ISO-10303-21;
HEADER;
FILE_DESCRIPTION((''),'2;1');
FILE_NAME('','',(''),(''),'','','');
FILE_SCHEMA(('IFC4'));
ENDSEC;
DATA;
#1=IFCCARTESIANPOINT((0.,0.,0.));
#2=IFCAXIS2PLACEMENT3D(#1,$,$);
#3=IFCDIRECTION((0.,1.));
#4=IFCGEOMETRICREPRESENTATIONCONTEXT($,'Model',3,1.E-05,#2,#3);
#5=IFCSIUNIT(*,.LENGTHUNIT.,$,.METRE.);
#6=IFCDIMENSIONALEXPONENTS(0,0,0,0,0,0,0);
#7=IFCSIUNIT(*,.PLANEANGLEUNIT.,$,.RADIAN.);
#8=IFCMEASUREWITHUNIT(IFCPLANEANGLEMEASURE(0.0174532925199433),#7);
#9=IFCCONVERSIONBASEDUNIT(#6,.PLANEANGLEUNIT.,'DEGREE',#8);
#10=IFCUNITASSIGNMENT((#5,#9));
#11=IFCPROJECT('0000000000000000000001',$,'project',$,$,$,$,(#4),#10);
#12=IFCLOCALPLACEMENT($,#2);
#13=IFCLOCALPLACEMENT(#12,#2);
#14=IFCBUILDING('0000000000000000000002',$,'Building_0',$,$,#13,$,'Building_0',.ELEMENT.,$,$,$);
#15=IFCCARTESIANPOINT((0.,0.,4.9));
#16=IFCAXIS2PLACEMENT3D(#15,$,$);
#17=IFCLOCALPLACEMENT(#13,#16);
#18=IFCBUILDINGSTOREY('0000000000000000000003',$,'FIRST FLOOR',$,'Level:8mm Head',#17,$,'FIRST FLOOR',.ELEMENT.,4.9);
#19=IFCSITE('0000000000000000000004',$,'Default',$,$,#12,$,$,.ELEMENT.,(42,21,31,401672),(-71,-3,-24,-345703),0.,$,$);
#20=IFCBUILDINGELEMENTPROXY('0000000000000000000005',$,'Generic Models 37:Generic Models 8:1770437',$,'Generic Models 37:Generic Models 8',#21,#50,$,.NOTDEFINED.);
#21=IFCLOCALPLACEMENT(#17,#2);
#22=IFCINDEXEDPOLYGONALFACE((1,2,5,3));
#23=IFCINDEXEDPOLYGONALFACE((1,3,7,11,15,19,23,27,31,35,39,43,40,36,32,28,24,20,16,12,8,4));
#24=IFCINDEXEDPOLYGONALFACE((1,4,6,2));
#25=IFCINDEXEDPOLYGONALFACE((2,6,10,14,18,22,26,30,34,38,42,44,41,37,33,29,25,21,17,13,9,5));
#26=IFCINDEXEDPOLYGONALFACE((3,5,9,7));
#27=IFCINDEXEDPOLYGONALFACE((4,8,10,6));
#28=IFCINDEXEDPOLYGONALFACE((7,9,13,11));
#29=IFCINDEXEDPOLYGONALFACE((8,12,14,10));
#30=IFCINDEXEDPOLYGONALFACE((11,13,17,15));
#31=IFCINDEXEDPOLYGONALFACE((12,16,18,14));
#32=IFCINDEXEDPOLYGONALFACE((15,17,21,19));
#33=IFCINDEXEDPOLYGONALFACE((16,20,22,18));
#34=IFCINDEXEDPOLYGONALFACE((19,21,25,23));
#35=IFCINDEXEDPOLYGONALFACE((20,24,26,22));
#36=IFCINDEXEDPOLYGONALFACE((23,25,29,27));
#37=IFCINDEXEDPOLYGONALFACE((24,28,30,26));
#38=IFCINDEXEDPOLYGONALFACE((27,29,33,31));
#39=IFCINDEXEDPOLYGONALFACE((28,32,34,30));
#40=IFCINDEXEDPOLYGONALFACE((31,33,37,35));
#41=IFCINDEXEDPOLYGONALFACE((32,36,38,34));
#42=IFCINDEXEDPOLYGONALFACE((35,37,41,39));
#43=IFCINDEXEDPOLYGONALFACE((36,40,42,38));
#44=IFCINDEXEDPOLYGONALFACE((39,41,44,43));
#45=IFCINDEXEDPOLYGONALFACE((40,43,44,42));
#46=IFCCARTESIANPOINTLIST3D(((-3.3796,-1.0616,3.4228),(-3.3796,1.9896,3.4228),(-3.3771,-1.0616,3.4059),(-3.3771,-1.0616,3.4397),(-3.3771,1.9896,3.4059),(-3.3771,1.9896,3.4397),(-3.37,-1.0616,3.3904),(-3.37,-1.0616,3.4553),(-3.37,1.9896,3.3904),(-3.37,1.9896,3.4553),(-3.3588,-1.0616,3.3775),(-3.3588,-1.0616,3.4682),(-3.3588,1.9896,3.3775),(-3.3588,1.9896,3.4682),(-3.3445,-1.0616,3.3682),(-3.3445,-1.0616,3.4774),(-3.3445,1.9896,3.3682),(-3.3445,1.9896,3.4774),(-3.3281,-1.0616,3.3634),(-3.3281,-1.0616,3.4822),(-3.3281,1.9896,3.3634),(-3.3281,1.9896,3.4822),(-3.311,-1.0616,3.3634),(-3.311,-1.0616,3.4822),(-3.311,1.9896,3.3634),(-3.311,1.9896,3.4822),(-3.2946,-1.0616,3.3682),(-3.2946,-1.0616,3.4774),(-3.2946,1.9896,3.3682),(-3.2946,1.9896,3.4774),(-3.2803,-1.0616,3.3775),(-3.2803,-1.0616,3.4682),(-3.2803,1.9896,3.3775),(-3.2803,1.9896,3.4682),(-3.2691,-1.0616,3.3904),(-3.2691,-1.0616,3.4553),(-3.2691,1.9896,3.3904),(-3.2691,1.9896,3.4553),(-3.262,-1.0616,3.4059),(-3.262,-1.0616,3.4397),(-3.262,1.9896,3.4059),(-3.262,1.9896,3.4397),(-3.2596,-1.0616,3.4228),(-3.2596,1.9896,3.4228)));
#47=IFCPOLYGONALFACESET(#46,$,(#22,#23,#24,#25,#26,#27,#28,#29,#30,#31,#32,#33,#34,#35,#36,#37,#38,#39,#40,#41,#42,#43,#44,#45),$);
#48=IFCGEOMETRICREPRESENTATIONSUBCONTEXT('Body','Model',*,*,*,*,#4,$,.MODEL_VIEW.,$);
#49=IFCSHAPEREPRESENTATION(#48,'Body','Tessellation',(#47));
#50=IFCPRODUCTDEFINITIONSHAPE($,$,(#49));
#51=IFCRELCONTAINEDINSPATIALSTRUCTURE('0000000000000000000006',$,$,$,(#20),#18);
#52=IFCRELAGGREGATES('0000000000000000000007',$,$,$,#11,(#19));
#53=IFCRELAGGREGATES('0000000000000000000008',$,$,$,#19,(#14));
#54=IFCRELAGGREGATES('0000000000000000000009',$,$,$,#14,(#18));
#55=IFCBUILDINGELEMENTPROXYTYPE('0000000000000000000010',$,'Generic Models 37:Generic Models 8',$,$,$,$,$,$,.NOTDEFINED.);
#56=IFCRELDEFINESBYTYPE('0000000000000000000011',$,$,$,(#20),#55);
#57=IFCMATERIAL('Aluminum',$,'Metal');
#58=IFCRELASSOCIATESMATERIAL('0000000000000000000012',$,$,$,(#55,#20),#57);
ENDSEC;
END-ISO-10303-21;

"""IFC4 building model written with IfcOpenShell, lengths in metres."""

from ifc_helpers import new_model, entity, si_unit, converted_unit, direction, frame, origin, place, context, subcontext, project, spatial, arc, indexed_curve, outline, extrude, source, transform, mapped, material, type_object, type_shapes, element, save


model = new_model("IFC4")

# Units and contexts
model_context = context("Model", 3, precision=1e-05, world=origin(), true_north=direction((0.0, 1.0)))
body_context = subcontext(model_context, "Body", "Model", "MODEL_VIEW")
ifc_project = project(units=[si_unit("LENGTHUNIT", "METRE"), converted_unit("PLANEANGLEUNIT", "DEGREE", entity("IfcPlaneAngleMeasure", 0.0174532925199433), si_unit("PLANEANGLEUNIT", "RADIAN"), dimensions=[0, 0, 0, 0, 0, 0, 0])], contexts=[model_context])

# Site, building, storey
site_placement = place(None, origin())
site = spatial("IfcSite", under=ifc_project, at=site_placement, Name="Default", CompositionType="ELEMENT", RefLatitude=(42, 21, 31, 401672), RefLongitude=(-71, -3, -24, -345703), RefElevation=0.0)
building_placement = place(site_placement, origin())
building = spatial("IfcBuilding", under=site, at=building_placement, Name="Building_0", LongName="Building_0", CompositionType="ELEMENT")
storey_placement = place(building_placement, frame((0.0, 0.0, 4.9)))
storey = spatial("IfcBuildingStorey", under=building, at=storey_placement, Name="FIRST FLOOR", ObjectType="Level:8mm Head", LongName="FIRST FLOOR", CompositionType="ELEMENT", Elevation=4.9)

# Building element proxy
ifc_material = material(Name="Aluminum", Category="Metal")
building_element_proxy_type_1 = type_object("IfcBuildingElementProxyType", Name="Generic Models 37:Generic Models 8", PredefinedType="NOTDEFINED", material=ifc_material)
shared_shape_1 = source(origin(), body_context, "Body", "SweptSolid", [
    extrude(outline(indexed_curve([(-0.06, 0.0), (0.0, -0.06), (0.06, 0.0), (0.0, 0.06)], segments=[arc(1, 2, 3), arc(3, 4, 1)], self_intersect=False)), frame((-3.3196, -1.0616, 8.3228), z_axis=(0.0, 1.0, 0.0), x_axis=(-1.0, 0.0, 0.0)), (0.0, 0.0, 1.0), 3.0512),
])
type_shapes(building_element_proxy_type_1, [shared_shape_1])
proxy_1_placement = place(storey_placement, frame((0.0, 0.0, -4.9)))
element("IfcBuildingElementProxy", 1, at=proxy_1_placement, inside=storey, type_object=building_element_proxy_type_1, material=ifc_material, Name="Generic Models 37:Generic Models 8:1770437", ObjectType="Generic Models 37:Generic Models 8", PredefinedType="NOTDEFINED", context=body_context, shape_type="MappedRepresentation", body=[
    mapped(shared_shape_1, transform((0.0, 0.0, 0.0), scale=1.0)),
])

save(model, "model.ifc")
